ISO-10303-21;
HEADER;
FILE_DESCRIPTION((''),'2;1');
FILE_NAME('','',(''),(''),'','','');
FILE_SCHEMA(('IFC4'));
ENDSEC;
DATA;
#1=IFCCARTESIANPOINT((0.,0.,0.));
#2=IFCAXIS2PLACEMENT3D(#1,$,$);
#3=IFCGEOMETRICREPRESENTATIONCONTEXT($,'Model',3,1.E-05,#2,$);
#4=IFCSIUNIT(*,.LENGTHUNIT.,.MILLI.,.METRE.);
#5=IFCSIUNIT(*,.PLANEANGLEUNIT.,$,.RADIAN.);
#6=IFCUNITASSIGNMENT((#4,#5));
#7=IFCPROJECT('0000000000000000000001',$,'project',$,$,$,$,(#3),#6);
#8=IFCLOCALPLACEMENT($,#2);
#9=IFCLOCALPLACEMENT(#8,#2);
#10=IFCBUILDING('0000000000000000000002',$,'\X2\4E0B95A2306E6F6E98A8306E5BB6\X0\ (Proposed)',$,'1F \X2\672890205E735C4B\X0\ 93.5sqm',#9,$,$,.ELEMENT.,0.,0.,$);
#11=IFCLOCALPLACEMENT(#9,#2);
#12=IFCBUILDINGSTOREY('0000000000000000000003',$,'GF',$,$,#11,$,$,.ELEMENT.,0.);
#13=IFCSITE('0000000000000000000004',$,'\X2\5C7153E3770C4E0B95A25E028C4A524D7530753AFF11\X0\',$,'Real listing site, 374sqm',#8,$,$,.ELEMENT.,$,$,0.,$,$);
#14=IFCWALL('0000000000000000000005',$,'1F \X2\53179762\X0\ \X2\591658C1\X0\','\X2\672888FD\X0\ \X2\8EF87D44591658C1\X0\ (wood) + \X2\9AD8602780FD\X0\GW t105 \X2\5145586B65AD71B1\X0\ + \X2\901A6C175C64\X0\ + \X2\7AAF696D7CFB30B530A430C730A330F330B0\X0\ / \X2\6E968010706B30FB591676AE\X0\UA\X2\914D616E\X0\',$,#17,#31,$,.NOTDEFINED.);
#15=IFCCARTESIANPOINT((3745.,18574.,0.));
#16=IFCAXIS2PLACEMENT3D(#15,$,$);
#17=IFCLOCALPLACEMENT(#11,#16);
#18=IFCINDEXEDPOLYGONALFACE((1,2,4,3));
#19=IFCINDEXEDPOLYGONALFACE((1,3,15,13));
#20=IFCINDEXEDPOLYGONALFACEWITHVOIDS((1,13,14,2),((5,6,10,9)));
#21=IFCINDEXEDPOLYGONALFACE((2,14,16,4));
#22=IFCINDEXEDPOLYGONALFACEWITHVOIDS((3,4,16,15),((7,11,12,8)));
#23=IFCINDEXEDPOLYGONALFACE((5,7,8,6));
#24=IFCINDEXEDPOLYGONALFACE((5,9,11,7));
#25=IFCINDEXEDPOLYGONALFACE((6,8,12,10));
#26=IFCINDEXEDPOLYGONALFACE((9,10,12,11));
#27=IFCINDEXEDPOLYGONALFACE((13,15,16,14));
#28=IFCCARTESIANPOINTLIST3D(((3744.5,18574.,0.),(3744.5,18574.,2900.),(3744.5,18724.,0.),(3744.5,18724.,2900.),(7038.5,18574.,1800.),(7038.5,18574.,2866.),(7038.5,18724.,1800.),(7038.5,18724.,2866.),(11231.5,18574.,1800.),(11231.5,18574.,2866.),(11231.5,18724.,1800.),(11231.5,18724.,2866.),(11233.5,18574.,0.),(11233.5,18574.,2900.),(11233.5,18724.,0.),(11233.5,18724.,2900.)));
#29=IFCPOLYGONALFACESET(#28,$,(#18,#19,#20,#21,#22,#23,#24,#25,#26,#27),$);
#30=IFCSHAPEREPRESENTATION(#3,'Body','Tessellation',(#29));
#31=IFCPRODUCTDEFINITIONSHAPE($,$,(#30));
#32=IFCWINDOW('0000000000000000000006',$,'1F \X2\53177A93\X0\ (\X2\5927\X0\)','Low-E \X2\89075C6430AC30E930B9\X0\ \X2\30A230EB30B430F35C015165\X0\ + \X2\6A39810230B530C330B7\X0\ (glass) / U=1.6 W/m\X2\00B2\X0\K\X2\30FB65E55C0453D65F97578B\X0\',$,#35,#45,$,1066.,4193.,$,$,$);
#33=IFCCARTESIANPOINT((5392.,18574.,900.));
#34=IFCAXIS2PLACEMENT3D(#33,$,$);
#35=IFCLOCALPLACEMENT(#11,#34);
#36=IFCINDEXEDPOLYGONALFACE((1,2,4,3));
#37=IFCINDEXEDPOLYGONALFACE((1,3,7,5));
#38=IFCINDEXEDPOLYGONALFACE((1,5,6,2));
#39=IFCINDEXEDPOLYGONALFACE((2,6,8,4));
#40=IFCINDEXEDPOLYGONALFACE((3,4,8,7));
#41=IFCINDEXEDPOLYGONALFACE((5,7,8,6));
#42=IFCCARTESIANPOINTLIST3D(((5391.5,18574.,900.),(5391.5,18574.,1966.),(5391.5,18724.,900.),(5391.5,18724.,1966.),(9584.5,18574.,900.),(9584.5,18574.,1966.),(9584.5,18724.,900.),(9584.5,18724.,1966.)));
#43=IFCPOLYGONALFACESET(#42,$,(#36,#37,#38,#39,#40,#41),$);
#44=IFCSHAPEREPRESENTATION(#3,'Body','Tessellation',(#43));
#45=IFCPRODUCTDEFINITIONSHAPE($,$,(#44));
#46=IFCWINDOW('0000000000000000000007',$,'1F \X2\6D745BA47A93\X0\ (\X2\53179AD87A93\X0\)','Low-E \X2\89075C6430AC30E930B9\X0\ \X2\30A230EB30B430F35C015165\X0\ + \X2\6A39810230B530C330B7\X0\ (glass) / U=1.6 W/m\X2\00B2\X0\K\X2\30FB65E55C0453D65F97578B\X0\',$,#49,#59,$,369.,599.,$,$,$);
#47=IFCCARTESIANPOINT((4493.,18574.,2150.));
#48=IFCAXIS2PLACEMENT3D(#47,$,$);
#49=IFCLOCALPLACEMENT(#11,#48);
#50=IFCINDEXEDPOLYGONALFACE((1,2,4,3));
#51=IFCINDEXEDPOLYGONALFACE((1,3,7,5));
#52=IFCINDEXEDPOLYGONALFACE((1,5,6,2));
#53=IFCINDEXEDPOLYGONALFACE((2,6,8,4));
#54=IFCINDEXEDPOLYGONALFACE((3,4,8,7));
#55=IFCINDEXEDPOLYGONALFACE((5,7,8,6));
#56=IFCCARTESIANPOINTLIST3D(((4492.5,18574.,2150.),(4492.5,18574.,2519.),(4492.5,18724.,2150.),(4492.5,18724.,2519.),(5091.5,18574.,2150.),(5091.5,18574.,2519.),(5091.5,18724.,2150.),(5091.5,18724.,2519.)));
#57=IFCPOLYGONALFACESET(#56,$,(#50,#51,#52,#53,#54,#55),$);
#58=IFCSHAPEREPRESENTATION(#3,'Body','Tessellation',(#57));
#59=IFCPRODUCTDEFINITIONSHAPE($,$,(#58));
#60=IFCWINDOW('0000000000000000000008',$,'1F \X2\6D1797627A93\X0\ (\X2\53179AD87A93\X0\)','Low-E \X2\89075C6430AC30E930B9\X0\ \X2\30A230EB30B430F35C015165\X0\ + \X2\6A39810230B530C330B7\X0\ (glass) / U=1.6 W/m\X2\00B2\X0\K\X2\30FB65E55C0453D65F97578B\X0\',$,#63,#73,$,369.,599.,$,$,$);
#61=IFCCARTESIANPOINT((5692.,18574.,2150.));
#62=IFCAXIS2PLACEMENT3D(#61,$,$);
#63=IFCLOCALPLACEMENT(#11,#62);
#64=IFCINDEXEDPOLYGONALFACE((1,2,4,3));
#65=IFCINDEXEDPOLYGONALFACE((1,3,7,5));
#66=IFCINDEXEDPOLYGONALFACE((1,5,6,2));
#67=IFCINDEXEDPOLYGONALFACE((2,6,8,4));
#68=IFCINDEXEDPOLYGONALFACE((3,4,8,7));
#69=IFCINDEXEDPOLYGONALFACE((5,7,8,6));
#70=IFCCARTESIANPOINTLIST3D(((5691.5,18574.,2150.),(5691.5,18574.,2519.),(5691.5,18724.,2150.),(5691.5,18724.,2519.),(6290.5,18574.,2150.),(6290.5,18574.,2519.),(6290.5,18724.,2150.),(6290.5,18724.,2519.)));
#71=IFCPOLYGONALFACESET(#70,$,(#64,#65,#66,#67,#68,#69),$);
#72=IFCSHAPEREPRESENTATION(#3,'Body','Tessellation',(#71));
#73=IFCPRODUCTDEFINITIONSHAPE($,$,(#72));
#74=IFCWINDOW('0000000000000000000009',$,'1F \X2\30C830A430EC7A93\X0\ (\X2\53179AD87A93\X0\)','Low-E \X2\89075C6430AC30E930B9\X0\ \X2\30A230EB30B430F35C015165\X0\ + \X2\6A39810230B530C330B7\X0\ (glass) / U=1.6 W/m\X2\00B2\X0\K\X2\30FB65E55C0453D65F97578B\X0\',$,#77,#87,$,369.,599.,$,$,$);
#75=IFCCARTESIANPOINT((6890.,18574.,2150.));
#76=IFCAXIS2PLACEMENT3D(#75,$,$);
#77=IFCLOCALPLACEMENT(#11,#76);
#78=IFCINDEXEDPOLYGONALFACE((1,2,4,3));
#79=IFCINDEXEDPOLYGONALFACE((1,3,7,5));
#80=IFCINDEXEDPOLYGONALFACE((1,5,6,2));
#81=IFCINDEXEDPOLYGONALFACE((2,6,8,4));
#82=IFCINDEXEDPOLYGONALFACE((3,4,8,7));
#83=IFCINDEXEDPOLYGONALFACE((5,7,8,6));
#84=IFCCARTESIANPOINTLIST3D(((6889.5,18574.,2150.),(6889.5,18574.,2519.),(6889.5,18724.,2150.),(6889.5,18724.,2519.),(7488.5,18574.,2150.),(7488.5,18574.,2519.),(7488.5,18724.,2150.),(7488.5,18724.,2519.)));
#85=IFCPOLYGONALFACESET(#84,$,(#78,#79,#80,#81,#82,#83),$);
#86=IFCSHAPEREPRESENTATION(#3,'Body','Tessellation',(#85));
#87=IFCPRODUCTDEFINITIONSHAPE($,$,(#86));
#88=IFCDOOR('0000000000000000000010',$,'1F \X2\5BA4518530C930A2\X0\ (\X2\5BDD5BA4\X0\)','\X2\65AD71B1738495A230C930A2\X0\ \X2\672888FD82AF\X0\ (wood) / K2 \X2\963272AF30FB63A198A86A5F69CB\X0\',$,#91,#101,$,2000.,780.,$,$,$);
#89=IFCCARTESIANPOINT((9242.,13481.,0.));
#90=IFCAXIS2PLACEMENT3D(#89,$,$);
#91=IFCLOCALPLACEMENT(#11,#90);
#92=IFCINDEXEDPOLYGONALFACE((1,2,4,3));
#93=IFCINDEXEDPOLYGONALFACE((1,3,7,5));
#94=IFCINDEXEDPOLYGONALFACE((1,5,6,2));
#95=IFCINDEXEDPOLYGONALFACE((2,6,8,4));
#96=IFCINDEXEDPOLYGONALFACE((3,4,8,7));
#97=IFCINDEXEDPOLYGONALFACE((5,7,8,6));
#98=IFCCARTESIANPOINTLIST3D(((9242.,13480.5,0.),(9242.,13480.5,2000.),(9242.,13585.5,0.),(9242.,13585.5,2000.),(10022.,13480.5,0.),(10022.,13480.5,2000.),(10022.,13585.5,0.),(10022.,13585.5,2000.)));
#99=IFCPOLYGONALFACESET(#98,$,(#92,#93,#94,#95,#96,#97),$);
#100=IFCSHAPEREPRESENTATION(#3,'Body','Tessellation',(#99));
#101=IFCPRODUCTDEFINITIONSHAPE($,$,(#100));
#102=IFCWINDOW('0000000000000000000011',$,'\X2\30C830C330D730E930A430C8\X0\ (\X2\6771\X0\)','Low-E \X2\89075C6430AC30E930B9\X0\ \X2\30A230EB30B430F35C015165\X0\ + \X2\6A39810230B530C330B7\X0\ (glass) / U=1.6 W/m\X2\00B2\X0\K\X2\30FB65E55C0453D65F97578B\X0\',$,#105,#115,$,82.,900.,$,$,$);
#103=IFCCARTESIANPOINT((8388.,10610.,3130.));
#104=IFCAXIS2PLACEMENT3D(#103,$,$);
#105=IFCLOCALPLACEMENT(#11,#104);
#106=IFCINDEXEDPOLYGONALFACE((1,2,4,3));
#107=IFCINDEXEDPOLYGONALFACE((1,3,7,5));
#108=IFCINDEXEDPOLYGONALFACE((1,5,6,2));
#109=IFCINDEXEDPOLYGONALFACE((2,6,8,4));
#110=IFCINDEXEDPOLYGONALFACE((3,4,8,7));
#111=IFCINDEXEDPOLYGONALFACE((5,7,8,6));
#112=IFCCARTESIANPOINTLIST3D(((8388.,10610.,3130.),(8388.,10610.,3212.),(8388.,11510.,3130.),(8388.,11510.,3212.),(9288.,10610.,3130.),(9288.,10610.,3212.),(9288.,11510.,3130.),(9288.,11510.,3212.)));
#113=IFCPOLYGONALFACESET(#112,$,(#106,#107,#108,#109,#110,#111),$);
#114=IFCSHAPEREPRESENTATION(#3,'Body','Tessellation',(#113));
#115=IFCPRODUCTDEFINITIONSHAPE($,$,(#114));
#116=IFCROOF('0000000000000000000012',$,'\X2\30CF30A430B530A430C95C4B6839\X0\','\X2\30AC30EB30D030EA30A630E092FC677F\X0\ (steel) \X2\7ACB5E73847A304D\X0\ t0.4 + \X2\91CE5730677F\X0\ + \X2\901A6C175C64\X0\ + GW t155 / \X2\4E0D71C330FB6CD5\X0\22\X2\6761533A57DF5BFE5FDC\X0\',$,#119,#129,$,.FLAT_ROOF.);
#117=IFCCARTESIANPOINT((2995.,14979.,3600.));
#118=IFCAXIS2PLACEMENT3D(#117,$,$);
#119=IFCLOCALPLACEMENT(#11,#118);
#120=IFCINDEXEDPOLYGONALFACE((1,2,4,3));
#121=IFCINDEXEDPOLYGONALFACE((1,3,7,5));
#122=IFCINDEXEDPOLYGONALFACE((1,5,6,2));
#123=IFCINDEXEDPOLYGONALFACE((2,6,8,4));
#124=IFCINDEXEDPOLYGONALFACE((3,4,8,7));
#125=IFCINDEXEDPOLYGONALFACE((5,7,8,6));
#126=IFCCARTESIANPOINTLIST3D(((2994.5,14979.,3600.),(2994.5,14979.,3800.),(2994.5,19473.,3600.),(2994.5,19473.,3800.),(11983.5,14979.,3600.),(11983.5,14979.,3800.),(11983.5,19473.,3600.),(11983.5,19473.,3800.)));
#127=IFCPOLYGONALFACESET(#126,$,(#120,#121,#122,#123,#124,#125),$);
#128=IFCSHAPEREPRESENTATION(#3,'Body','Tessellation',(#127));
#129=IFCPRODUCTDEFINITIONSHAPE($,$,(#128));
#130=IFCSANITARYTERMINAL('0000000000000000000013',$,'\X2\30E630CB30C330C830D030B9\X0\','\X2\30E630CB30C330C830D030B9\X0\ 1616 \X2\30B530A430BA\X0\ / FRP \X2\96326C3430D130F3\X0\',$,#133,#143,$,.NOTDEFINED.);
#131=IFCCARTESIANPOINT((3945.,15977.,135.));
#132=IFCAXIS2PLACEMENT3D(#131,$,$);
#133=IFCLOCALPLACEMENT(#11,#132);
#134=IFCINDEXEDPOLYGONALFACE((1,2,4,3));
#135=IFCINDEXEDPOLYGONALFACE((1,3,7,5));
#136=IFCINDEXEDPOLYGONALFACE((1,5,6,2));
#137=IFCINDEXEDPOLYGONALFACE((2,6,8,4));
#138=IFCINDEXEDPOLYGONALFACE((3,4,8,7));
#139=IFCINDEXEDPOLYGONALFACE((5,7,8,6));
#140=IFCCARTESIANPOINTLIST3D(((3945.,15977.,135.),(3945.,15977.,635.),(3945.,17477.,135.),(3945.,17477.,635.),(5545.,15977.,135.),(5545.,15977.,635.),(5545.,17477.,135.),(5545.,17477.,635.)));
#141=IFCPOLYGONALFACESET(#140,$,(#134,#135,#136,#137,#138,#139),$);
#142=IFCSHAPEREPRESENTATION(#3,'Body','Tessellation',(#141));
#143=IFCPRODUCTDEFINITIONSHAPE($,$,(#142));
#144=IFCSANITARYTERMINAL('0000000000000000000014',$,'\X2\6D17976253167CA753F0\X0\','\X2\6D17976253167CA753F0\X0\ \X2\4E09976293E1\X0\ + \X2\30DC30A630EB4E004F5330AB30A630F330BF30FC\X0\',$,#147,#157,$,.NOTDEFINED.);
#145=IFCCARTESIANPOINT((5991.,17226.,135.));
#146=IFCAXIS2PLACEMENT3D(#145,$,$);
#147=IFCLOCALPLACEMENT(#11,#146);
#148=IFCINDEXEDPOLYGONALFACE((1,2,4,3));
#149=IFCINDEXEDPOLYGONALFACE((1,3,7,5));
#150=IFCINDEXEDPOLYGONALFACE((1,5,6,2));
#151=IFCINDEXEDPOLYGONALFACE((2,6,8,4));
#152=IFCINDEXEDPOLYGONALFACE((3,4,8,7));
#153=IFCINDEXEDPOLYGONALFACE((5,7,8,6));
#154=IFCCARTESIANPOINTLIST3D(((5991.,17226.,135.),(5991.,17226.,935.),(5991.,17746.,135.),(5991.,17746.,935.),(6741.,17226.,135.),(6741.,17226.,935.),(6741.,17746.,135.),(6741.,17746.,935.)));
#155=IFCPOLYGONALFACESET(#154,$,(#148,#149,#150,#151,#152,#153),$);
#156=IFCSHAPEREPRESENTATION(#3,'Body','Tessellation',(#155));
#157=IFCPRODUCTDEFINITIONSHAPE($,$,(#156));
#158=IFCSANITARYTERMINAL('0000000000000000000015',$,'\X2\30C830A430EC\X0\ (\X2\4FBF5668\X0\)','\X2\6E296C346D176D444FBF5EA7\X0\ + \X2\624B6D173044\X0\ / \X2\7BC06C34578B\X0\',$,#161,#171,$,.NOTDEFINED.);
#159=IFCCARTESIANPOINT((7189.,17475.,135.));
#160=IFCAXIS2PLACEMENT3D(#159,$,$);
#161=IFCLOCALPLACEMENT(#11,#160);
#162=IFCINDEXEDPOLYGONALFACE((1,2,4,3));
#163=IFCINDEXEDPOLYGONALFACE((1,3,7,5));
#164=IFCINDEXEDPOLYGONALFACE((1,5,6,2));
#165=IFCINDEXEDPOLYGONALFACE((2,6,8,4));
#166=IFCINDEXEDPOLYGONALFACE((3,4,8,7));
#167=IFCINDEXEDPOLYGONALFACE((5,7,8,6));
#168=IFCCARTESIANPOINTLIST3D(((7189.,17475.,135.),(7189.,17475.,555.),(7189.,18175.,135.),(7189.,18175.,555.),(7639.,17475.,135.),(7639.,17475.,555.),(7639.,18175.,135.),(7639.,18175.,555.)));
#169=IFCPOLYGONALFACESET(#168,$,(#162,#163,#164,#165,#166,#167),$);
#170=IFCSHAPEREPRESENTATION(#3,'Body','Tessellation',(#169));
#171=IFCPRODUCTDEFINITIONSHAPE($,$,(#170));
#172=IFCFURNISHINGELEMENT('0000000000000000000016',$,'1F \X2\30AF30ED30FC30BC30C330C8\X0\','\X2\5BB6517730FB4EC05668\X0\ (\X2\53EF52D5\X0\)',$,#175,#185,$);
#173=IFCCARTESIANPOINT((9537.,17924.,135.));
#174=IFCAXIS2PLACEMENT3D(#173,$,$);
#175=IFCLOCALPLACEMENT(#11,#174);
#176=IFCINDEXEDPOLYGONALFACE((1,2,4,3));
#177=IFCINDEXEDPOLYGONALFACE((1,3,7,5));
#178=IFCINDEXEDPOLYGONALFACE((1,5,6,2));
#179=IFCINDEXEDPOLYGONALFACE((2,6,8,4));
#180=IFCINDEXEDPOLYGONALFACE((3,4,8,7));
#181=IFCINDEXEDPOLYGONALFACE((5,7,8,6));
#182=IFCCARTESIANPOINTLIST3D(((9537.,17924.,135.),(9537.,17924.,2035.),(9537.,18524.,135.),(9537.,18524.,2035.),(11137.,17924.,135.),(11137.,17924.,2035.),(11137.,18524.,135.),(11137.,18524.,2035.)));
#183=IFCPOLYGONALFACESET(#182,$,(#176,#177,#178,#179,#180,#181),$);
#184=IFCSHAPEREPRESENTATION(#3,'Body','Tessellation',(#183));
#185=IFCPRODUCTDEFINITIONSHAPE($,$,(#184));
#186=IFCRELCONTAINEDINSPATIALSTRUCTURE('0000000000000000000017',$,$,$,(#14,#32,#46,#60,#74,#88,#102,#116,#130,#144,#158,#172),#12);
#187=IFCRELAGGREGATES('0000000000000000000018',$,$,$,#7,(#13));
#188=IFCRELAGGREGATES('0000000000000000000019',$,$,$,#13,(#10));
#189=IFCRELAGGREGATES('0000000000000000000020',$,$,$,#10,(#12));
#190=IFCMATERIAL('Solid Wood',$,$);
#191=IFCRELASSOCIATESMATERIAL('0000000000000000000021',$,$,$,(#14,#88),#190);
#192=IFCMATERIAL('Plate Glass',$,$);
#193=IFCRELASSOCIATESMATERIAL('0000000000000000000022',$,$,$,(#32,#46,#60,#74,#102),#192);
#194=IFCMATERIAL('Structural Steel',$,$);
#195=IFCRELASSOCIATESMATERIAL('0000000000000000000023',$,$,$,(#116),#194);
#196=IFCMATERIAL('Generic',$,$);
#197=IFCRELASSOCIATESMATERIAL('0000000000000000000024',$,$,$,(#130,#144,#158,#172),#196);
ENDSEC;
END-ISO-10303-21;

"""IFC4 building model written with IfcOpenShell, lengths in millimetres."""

from ifc_helpers import new_model, si_unit, frame, frame_2d, origin, place, context, project, spatial, rectangle, extrude, material, element, fill, save


model = new_model("IFC4")

# Units and contexts
model_context = context("Model", 3, precision=1e-05, world=origin())
ifc_project = project(units=[si_unit("LENGTHUNIT", "METRE", prefix="MILLI"), si_unit("PLANEANGLEUNIT", "RADIAN")], contexts=[model_context])

# Site, building, storey
site_placement = place(None, origin())
site = spatial("IfcSite", under=ifc_project, at=site_placement, Name="山口県下関市豊前田町１", ObjectType="Real listing site, 374sqm", CompositionType="ELEMENT", RefElevation=0.0)
building_placement = place(site_placement, origin())
building = spatial("IfcBuilding", under=site, at=building_placement, Name="下関の潮風の家 (Proposed)", ObjectType="1F 木造平屋 93.5sqm", CompositionType="ELEMENT", ElevationOfRefHeight=0.0, ElevationOfTerrain=0.0)
storey_placement = place(building_placement, origin())
storey = spatial("IfcBuildingStorey", under=building, at=storey_placement, Name="GF", CompositionType="ELEMENT", Elevation=0.0)

# Shared definitions
ifc_material_1 = material(Name="Solid Wood")

# Wall, openings, windows
wall_1_placement = place(storey_placement, frame((3745.0, 18574.0, 0.0)))
wall_1 = element("IfcWall", 1, at=wall_1_placement, inside=storey, material=ifc_material_1, Name="1F 北面 外壁", Description="木製 軸組外壁 (wood) + 高性能GW t105 充填断熱 + 通気層 + 窯業系サイディング / 準耐火・外皮UA配慮", PredefinedType="NOTDEFINED", context=model_context, shape_type="SweptSolid", body=[
    extrude(rectangle(XDim=7489.0, YDim=150.0, at=frame_2d((3744.0, 75.0))), frame((3745.0, 18574.0, 0.0)), (0.0, 0.0, 1.0), 2900.0),
])
opening_1_placement = place(storey_placement, frame((5392.0, 18574.0, 900.0)))
opening_1 = element("IfcOpeningElement", 2, at=opening_1_placement, cuts=wall_1, PredefinedType="NOTDEFINED", context=model_context, shape_type="SweptSolid", body=[
    extrude(rectangle(XDim=4193.0, YDim=150.0, at=frame_2d((2096.0, 75.0))), frame((5392.0, 18574.0, 900.0)), (0.0, 0.0, 1.0), 1066.0),
])
opening_2_placement = place(storey_placement, frame((4493.0, 18574.0, 2150.0)))
opening_2 = element("IfcOpeningElement", 3, at=opening_2_placement, cuts=wall_1, PredefinedType="NOTDEFINED", context=model_context, shape_type="SweptSolid", body=[
    extrude(rectangle(XDim=599.0, YDim=150.0, at=frame_2d((299.0, 75.0))), frame((4493.0, 18574.0, 2150.0)), (0.0, 0.0, 1.0), 369.0),
])
opening_3_placement = place(storey_placement, frame((5692.0, 18574.0, 2150.0)))
opening_3 = element("IfcOpeningElement", 4, at=opening_3_placement, cuts=wall_1, PredefinedType="NOTDEFINED", context=model_context, shape_type="SweptSolid", body=[
    extrude(rectangle(XDim=599.0, YDim=150.0, at=frame_2d((299.0, 75.0))), frame((5692.0, 18574.0, 2150.0)), (0.0, 0.0, 1.0), 369.0),
])
opening_4_placement = place(storey_placement, frame((6890.0, 18574.0, 2150.0)))
opening_4 = element("IfcOpeningElement", 5, at=opening_4_placement, cuts=wall_1, PredefinedType="NOTDEFINED", context=model_context, shape_type="SweptSolid", body=[
    extrude(rectangle(XDim=599.0, YDim=150.0, at=frame_2d((299.0, 75.0))), frame((6890.0, 18574.0, 2150.0)), (0.0, 0.0, 1.0), 369.0),
])
ifc_material_2 = material(Name="Plate Glass")
window_1_placement = place(storey_placement, frame((5392.0, 18574.0, 900.0)))
window_1 = element("IfcWindow", 6, at=window_1_placement, inside=storey, material=ifc_material_2, Name="1F 北窓 (大)", Description="Low-E 複層ガラス アルゴン封入 + 樹脂サッシ (glass) / U=1.6 W/m²K・日射取得型", OverallHeight=1066.0, OverallWidth=4193.0, context=model_context, shape_type="SweptSolid", body=[
    extrude(rectangle(XDim=4193.0, YDim=150.0, at=frame_2d((2096.0, 75.0))), frame((5392.0, 18574.0, 900.0)), (0.0, 0.0, 1.0), 1066.0),
])
fill(opening_1, window_1)
window_2_placement = place(storey_placement, frame((4493.0, 18574.0, 2150.0)))
window_2 = element("IfcWindow", 7, at=window_2_placement, inside=storey, material=ifc_material_2, Name="1F 浴室窓 (北高窓)", Description="Low-E 複層ガラス アルゴン封入 + 樹脂サッシ (glass) / U=1.6 W/m²K・日射取得型", OverallHeight=369.0, OverallWidth=599.0, context=model_context, shape_type="SweptSolid", body=[
    extrude(rectangle(XDim=599.0, YDim=150.0, at=frame_2d((299.0, 75.0))), frame((4493.0, 18574.0, 2150.0)), (0.0, 0.0, 1.0), 369.0),
])
fill(opening_2, window_2)
window_3_placement = place(storey_placement, frame((5692.0, 18574.0, 2150.0)))
window_3 = element("IfcWindow", 8, at=window_3_placement, inside=storey, material=ifc_material_2, Name="1F 洗面窓 (北高窓)", Description="Low-E 複層ガラス アルゴン封入 + 樹脂サッシ (glass) / U=1.6 W/m²K・日射取得型", OverallHeight=369.0, OverallWidth=599.0, context=model_context, shape_type="SweptSolid", body=[
    extrude(rectangle(XDim=599.0, YDim=150.0, at=frame_2d((299.0, 75.0))), frame((5692.0, 18574.0, 2150.0)), (0.0, 0.0, 1.0), 369.0),
])
fill(opening_3, window_3)
window_4_placement = place(storey_placement, frame((6890.0, 18574.0, 2150.0)))
window_4 = element("IfcWindow", 9, at=window_4_placement, inside=storey, material=ifc_material_2, Name="1F トイレ窓 (北高窓)", Description="Low-E 複層ガラス アルゴン封入 + 樹脂サッシ (glass) / U=1.6 W/m²K・日射取得型", OverallHeight=369.0, OverallWidth=599.0, context=model_context, shape_type="SweptSolid", body=[
    extrude(rectangle(XDim=599.0, YDim=150.0, at=frame_2d((299.0, 75.0))), frame((6890.0, 18574.0, 2150.0)), (0.0, 0.0, 1.0), 369.0),
])
fill(opening_4, window_4)

# Door
door_1_placement = place(storey_placement, frame((9242.0, 13481.0, 0.0)))
element("IfcDoor", 10, at=door_1_placement, inside=storey, material=ifc_material_1, Name="1F 室内ドア (寝室)", Description="断熱玄関ドア 木製芯 (wood) / K2 防犯・採風機構", OverallHeight=2000.0, OverallWidth=780.0, context=model_context, shape_type="SweptSolid", body=[
    extrude(rectangle(XDim=780.0, YDim=105.0, at=frame_2d((390.0, 52.0))), frame((9242.0, 13481.0, 0.0)), (0.0, 0.0, 1.0), 2000.0),
])

# Window
window_5_placement = place(storey_placement, frame((8388.0, 10610.0, 3130.0)))
element("IfcWindow", 11, at=window_5_placement, inside=storey, material=ifc_material_2, Name="トップライト (東)", Description="Low-E 複層ガラス アルゴン封入 + 樹脂サッシ (glass) / U=1.6 W/m²K・日射取得型", OverallHeight=82.0, OverallWidth=900.0, context=model_context, shape_type="SweptSolid", body=[
    extrude(rectangle(XDim=900.0, YDim=900.0, at=frame_2d((450.0, 450.0))), frame((8388.0, 10610.0, 3130.0)), (0.0, 0.0, 1.0), 82.0),
])

# Roof
ifc_material_3 = material(Name="Structural Steel")
roof_placement = place(storey_placement, frame((2995.0, 14979.0, 3600.0)))
element("IfcRoof", 12, at=roof_placement, inside=storey, material=ifc_material_3, Name="ハイサイド屋根", Description="ガルバリウム鋼板 (steel) 立平葺き t0.4 + 野地板 + 通気層 + GW t155 / 不燃・法22条区域対応", PredefinedType="FLAT_ROOF", context=model_context, shape_type="SweptSolid", body=[
    extrude(rectangle(XDim=8989.0, YDim=4494.0, at=frame_2d((4494.0, 2247.0))), frame((2995.0, 14979.0, 3600.0)), (0.0, 0.0, 1.0), 200.0),
])

# Sanitary terminals
ifc_material_4 = material(Name="Generic")
sanitary_terminal_1_placement = place(storey_placement, frame((3945.0, 15977.0, 135.0)))
element("IfcSanitaryTerminal", 13, at=sanitary_terminal_1_placement, inside=storey, material=ifc_material_4, Name="ユニットバス", Description="ユニットバス 1616 サイズ / FRP 防水パン", PredefinedType="NOTDEFINED", context=model_context, shape_type="SweptSolid", body=[
    extrude(rectangle(XDim=1600.0, YDim=1500.0, at=frame_2d((800.0, 750.0))), frame((3945.0, 15977.0, 135.0)), (0.0, 0.0, 1.0), 500.0),
])
sanitary_terminal_2_placement = place(storey_placement, frame((5991.0, 17226.0, 135.0)))
element("IfcSanitaryTerminal", 14, at=sanitary_terminal_2_placement, inside=storey, material=ifc_material_4, Name="洗面化粧台", Description="洗面化粧台 三面鏡 + ボウル一体カウンター", PredefinedType="NOTDEFINED", context=model_context, shape_type="SweptSolid", body=[
    extrude(rectangle(XDim=750.0, YDim=520.0, at=frame_2d((375.0, 260.0))), frame((5991.0, 17226.0, 135.0)), (0.0, 0.0, 1.0), 800.0),
])
sanitary_terminal_3_placement = place(storey_placement, frame((7189.0, 17475.0, 135.0)))
element("IfcSanitaryTerminal", 15, at=sanitary_terminal_3_placement, inside=storey, material=ifc_material_4, Name="トイレ (便器)", Description="温水洗浄便座 + 手洗い / 節水型", PredefinedType="NOTDEFINED", context=model_context, shape_type="SweptSolid", body=[
    extrude(rectangle(XDim=450.0, YDim=700.0, at=frame_2d((225.0, 350.0))), frame((7189.0, 17475.0, 135.0)), (0.0, 0.0, 1.0), 420.0),
])

# Furnishing element
furnishing_1_placement = place(storey_placement, frame((9537.0, 17924.0, 135.0)))
element("IfcFurnishingElement", 16, at=furnishing_1_placement, inside=storey, material=ifc_material_4, Name="1F クローゼット", Description="家具・什器 (可動)", context=model_context, shape_type="SweptSolid", body=[
    extrude(rectangle(XDim=1600.0, YDim=600.0, at=frame_2d((800.0, 300.0))), frame((9537.0, 17924.0, 135.0)), (0.0, 0.0, 1.0), 1900.0),
])

save(model, "model.ifc")
